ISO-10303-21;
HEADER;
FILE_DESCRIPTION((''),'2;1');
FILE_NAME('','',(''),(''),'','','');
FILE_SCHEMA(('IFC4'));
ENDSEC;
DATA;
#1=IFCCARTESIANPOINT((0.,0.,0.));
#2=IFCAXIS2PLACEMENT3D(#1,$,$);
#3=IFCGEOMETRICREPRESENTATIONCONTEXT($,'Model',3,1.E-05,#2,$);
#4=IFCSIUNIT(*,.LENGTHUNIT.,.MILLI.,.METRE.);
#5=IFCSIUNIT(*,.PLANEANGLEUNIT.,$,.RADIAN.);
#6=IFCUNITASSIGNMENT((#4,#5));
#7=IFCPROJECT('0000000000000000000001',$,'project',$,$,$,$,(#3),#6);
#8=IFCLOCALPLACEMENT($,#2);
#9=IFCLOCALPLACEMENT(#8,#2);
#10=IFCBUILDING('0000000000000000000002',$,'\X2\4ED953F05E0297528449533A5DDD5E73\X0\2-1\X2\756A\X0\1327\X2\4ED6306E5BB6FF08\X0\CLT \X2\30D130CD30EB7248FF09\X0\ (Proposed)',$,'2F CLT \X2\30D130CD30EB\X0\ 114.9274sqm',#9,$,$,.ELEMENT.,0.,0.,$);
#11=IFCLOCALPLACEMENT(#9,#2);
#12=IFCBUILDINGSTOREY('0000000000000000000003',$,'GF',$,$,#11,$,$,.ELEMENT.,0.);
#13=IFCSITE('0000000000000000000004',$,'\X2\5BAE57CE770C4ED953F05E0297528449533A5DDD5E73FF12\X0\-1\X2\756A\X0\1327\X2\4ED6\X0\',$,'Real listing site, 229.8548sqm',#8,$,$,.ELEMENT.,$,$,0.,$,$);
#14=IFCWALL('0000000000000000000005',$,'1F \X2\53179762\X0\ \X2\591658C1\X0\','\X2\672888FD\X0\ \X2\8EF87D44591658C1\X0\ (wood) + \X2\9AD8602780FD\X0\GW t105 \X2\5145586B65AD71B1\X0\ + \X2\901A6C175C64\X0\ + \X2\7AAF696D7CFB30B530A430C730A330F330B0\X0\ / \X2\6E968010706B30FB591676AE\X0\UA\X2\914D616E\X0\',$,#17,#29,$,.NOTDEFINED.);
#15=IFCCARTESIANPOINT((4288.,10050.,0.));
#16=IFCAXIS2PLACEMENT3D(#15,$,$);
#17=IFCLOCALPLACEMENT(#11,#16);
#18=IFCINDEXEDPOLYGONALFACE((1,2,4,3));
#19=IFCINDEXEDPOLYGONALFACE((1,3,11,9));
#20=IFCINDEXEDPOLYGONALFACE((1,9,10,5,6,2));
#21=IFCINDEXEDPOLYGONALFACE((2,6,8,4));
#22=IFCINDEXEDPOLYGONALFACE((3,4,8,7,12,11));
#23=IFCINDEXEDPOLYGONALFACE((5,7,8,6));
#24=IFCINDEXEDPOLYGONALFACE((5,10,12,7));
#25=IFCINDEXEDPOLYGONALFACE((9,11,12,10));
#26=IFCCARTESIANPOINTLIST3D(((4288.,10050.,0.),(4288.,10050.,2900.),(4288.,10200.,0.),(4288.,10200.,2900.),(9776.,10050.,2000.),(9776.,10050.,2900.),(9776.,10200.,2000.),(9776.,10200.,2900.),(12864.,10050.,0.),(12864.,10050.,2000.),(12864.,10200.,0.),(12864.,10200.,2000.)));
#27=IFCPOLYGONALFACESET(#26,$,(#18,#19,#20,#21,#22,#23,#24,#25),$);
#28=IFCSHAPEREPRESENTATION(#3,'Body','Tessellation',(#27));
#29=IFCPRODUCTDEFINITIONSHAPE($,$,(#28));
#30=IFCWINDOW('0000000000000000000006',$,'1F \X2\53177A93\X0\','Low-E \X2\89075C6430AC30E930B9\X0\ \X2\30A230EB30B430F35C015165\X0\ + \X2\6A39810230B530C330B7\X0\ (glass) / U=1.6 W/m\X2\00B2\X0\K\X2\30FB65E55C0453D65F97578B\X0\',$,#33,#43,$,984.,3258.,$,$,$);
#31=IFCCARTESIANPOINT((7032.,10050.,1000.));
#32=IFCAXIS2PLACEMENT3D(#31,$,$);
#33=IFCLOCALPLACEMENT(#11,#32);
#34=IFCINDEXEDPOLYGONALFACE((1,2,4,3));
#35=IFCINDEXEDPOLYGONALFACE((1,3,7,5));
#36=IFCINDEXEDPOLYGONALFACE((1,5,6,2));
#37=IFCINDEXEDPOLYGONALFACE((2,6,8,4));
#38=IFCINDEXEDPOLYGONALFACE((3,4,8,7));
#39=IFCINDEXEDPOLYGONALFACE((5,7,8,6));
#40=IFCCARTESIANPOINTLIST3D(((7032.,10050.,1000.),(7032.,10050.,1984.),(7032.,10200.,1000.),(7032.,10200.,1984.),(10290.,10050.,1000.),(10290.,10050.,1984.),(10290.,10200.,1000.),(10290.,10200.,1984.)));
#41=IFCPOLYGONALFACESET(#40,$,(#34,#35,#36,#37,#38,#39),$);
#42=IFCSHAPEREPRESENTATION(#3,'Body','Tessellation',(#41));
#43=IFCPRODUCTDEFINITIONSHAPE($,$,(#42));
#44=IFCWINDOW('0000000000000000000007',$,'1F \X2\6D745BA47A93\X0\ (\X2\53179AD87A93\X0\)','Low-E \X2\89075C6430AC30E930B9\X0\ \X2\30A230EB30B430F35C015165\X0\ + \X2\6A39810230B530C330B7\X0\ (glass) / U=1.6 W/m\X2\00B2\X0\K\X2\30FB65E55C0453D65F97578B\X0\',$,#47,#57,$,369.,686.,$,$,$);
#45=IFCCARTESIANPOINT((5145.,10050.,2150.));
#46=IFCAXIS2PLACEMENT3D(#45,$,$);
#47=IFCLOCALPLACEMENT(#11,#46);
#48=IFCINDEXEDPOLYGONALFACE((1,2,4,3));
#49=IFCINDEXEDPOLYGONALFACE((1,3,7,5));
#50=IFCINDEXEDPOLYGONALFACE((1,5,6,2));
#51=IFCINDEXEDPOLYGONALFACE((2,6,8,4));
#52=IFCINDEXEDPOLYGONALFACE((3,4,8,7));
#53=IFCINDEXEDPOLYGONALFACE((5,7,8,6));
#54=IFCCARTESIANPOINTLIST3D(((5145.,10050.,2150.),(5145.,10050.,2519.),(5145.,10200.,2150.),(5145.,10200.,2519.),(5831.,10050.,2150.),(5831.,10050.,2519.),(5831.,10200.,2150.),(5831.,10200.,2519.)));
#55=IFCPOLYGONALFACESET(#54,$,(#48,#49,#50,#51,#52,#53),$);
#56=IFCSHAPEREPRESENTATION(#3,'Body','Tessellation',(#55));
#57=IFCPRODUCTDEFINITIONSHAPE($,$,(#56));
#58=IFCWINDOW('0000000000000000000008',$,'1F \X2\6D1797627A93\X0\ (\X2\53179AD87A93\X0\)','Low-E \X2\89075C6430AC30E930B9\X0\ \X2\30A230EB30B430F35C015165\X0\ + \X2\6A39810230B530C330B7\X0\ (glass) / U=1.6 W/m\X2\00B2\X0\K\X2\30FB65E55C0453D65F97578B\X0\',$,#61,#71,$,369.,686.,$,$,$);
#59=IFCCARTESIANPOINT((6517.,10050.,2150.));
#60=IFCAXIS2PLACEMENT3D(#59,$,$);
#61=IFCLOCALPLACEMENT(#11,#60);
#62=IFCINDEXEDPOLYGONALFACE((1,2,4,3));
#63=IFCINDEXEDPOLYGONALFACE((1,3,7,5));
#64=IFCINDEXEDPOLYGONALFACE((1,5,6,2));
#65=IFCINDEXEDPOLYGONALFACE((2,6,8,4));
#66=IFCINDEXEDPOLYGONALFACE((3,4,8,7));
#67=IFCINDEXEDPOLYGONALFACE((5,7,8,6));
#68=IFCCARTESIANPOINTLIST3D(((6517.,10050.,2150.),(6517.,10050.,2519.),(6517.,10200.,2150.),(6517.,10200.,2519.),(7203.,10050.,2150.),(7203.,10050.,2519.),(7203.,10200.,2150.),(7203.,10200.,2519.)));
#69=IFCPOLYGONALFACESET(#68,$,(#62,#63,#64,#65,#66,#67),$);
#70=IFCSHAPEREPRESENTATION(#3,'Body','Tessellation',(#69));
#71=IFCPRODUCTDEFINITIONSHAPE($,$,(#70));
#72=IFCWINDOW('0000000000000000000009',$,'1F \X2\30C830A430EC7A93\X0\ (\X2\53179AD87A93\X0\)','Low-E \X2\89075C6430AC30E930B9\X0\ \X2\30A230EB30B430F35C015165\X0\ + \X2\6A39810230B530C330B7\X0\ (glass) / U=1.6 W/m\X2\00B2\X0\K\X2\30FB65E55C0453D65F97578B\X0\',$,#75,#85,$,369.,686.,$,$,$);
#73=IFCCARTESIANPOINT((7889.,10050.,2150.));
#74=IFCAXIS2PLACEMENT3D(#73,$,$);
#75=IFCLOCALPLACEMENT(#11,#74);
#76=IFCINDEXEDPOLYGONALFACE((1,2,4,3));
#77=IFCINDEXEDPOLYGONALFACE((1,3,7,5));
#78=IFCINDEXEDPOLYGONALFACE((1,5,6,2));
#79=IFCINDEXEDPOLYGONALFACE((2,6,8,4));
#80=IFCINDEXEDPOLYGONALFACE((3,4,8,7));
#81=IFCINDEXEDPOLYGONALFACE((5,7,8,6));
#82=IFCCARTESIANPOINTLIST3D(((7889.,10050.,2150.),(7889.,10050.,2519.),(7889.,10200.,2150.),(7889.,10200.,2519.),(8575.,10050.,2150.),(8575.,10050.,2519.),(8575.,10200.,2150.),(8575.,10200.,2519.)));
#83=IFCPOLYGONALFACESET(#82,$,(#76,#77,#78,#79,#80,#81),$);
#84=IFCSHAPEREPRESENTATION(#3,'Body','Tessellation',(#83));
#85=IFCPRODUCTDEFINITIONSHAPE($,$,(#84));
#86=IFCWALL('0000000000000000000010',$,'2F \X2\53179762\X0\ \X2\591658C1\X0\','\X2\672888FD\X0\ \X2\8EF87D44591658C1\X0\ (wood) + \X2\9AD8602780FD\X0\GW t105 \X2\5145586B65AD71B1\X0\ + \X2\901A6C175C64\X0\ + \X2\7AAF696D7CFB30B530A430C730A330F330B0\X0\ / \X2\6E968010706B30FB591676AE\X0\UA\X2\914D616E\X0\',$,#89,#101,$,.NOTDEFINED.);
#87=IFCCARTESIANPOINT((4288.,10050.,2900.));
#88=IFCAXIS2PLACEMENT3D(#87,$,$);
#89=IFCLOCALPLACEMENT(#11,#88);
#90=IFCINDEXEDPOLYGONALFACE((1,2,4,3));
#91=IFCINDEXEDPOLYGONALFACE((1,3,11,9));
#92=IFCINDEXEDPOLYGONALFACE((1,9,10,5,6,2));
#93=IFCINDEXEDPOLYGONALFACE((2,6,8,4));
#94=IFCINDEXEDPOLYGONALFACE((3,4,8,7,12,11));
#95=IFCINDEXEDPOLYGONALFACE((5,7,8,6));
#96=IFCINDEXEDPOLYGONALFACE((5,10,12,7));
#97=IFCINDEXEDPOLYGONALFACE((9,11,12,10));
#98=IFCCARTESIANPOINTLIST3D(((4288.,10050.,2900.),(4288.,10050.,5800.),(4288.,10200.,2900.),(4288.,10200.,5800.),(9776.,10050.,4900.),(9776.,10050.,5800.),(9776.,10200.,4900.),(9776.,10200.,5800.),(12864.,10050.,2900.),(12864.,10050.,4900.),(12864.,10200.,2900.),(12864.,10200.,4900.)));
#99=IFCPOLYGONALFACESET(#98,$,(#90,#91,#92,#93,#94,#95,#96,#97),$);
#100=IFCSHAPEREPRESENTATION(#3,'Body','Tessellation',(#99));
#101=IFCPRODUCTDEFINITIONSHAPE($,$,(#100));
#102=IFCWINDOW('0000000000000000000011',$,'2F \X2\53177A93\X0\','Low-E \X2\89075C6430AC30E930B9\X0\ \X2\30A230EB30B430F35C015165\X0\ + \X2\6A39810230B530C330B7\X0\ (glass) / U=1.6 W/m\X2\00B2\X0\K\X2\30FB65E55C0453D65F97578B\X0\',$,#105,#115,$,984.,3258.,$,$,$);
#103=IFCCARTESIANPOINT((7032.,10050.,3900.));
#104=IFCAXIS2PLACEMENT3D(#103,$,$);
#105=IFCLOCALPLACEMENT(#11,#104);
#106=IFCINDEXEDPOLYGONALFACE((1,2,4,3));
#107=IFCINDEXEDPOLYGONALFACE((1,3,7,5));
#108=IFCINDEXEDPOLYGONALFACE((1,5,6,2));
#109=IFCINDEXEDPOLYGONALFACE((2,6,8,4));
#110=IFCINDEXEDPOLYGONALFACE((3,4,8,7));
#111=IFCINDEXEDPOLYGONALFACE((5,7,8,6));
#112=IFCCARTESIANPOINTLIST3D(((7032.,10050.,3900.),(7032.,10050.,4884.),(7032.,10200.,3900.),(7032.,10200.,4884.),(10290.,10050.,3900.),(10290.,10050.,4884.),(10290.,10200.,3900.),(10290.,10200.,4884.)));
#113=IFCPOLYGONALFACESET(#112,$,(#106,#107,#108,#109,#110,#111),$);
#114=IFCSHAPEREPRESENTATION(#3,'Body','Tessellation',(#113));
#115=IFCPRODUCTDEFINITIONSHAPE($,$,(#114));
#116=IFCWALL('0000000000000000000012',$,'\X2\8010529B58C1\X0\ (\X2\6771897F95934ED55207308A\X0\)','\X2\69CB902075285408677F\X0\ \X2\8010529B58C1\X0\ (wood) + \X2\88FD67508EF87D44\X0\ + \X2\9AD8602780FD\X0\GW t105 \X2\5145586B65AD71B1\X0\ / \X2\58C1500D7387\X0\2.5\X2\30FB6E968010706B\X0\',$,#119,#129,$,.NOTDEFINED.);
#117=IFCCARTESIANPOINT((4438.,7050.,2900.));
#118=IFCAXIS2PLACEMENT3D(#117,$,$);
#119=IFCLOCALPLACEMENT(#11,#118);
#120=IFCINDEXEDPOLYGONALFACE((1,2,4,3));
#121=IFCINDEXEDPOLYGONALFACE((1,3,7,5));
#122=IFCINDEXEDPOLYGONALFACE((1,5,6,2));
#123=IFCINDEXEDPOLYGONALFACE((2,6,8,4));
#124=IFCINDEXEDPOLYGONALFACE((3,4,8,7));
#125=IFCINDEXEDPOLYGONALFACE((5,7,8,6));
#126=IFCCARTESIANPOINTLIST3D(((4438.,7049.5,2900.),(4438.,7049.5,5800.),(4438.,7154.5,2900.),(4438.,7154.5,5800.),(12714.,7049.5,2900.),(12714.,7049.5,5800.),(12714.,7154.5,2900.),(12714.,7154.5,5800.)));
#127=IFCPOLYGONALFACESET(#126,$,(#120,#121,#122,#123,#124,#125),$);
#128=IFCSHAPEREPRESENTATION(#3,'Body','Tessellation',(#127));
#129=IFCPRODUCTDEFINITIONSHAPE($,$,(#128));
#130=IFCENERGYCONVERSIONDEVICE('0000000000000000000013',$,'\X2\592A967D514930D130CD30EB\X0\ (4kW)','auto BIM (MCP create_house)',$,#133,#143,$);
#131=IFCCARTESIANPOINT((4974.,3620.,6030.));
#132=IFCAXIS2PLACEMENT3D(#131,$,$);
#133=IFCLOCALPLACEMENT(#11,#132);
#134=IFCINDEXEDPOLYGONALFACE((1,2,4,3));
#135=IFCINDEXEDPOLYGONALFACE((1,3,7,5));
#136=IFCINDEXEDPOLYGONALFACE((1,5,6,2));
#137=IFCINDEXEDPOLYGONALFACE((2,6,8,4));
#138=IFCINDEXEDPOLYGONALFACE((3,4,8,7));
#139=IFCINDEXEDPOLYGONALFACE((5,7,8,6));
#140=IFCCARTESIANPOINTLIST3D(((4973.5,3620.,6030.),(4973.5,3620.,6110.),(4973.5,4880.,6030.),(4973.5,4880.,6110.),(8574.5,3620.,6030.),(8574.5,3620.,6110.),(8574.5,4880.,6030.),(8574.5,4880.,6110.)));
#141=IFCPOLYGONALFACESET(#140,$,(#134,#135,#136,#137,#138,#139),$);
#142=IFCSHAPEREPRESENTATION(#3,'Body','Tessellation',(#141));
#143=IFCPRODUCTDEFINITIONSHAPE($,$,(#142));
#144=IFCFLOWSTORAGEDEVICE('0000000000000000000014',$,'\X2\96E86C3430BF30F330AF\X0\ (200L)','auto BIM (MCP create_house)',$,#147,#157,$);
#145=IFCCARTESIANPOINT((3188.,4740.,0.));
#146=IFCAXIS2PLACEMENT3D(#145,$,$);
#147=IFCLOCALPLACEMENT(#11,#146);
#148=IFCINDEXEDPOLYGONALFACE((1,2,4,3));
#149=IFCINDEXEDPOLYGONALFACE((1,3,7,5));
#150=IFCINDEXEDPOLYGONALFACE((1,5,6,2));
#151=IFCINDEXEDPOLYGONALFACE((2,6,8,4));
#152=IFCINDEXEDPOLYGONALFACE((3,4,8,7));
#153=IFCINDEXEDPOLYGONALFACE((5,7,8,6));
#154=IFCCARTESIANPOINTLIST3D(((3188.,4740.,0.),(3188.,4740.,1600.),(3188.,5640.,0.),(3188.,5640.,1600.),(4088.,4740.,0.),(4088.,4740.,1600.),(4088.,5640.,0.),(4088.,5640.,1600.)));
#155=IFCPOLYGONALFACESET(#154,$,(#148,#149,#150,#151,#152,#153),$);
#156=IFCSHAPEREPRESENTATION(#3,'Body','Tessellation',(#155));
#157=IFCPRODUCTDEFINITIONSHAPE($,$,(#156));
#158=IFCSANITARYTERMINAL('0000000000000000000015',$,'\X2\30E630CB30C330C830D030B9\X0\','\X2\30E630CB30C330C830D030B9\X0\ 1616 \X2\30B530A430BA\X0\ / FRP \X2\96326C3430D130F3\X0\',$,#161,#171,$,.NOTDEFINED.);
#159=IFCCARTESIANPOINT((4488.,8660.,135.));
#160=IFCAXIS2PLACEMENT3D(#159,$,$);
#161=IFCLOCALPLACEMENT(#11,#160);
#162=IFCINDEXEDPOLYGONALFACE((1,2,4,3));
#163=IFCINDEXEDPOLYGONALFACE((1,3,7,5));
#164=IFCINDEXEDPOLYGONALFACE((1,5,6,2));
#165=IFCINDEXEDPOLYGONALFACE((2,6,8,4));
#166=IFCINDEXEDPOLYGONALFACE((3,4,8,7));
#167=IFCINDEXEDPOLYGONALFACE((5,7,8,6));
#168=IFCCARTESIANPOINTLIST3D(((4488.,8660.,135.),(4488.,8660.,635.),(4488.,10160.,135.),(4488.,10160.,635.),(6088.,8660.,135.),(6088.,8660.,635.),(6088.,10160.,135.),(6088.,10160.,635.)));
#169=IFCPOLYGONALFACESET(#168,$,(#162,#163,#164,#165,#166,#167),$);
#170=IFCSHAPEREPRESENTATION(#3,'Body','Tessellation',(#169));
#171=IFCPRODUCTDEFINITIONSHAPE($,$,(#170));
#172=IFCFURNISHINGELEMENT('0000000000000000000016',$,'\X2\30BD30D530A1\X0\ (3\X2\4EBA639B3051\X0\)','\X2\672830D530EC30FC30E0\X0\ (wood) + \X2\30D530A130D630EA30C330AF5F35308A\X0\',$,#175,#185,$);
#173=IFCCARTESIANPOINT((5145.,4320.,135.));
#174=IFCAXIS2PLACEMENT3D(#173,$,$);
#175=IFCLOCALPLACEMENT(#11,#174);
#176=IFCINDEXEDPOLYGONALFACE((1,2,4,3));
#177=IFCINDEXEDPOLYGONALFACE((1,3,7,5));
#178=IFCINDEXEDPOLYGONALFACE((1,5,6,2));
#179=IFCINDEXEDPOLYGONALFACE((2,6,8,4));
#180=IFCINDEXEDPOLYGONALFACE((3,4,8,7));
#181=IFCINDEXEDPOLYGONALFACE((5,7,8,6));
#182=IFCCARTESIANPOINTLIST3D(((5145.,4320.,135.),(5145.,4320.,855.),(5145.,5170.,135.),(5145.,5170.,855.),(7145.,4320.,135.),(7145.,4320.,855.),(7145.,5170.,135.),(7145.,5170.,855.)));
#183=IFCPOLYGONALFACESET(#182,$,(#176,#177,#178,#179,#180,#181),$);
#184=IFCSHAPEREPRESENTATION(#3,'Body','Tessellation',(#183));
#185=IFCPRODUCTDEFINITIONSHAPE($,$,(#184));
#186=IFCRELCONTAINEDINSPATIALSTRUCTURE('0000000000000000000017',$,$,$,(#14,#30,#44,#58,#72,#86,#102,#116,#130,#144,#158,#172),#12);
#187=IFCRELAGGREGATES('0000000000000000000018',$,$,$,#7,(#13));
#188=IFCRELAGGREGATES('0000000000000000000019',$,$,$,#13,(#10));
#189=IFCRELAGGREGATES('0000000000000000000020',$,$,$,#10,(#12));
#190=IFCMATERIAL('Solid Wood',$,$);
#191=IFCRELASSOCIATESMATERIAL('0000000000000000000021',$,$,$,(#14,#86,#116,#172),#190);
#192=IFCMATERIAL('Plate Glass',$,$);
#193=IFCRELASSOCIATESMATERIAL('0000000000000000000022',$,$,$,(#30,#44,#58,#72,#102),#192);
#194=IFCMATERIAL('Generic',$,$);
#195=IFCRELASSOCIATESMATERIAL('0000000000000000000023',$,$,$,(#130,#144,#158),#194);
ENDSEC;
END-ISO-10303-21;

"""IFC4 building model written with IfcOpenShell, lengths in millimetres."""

from ifc_helpers import new_model, si_unit, frame, frame_2d, origin, place, context, project, spatial, rectangle, extrude, material, element, fill, save


model = new_model("IFC4")

# Units and contexts
model_context = context("Model", 3, precision=1e-05, world=origin())
ifc_project = project(units=[si_unit("LENGTHUNIT", "METRE", prefix="MILLI"), si_unit("PLANEANGLEUNIT", "RADIAN")], contexts=[model_context])

# Site, building, storey
site_placement = place(None, origin())
site = spatial("IfcSite", under=ifc_project, at=site_placement, Name="宮城県仙台市青葉区川平２-1番1327他", ObjectType="Real listing site, 229.8548sqm", CompositionType="ELEMENT", RefElevation=0.0)
building_placement = place(site_placement, origin())
building = spatial("IfcBuilding", under=site, at=building_placement, Name="仙台市青葉区川平2-1番1327他の家（CLT パネル版） (Proposed)", ObjectType="2F CLT パネル 114.9274sqm", CompositionType="ELEMENT", ElevationOfRefHeight=0.0, ElevationOfTerrain=0.0)
storey_placement = place(building_placement, origin())
storey = spatial("IfcBuildingStorey", under=building, at=storey_placement, Name="GF", CompositionType="ELEMENT", Elevation=0.0)

# Wall, openings, windows
ifc_material_1 = material(Name="Solid Wood")
wall_1_placement = place(storey_placement, frame((4288.0, 10050.0, 0.0)))
wall_1 = element("IfcWall", 1, at=wall_1_placement, inside=storey, material=ifc_material_1, Name="1F 北面 外壁", Description="木製 軸組外壁 (wood) + 高性能GW t105 充填断熱 + 通気層 + 窯業系サイディング / 準耐火・外皮UA配慮", PredefinedType="NOTDEFINED", context=model_context, shape_type="SweptSolid", body=[
    extrude(rectangle(XDim=8576.0, YDim=150.0, at=frame_2d((4288.0, 75.0))), frame((4288.0, 10050.0, 0.0)), (0.0, 0.0, 1.0), 2900.0),
])
opening_1_placement = place(storey_placement, frame((7032.0, 10050.0, 1000.0)))
opening_1 = element("IfcOpeningElement", 2, at=opening_1_placement, cuts=wall_1, PredefinedType="NOTDEFINED", context=model_context, shape_type="SweptSolid", body=[
    extrude(rectangle(XDim=3258.0, YDim=150.0, at=frame_2d((1629.0, 75.0))), frame((7032.0, 10050.0, 1000.0)), (0.0, 0.0, 1.0), 984.0),
])
opening_2_placement = place(storey_placement, frame((5145.0, 10050.0, 2150.0)))
opening_2 = element("IfcOpeningElement", 3, at=opening_2_placement, cuts=wall_1, PredefinedType="NOTDEFINED", context=model_context, shape_type="SweptSolid", body=[
    extrude(rectangle(XDim=686.0, YDim=150.0, at=frame_2d((343.0, 75.0))), frame((5145.0, 10050.0, 2150.0)), (0.0, 0.0, 1.0), 369.0),
])
opening_3_placement = place(storey_placement, frame((6517.0, 10050.0, 2150.0)))
opening_3 = element("IfcOpeningElement", 4, at=opening_3_placement, cuts=wall_1, PredefinedType="NOTDEFINED", context=model_context, shape_type="SweptSolid", body=[
    extrude(rectangle(XDim=686.0, YDim=150.0, at=frame_2d((343.0, 75.0))), frame((6517.0, 10050.0, 2150.0)), (0.0, 0.0, 1.0), 369.0),
])
opening_4_placement = place(storey_placement, frame((7889.0, 10050.0, 2150.0)))
opening_4 = element("IfcOpeningElement", 5, at=opening_4_placement, cuts=wall_1, PredefinedType="NOTDEFINED", context=model_context, shape_type="SweptSolid", body=[
    extrude(rectangle(XDim=686.0, YDim=150.0, at=frame_2d((343.0, 75.0))), frame((7889.0, 10050.0, 2150.0)), (0.0, 0.0, 1.0), 369.0),
])
ifc_material_2 = material(Name="Plate Glass")
window_1_placement = place(storey_placement, frame((7032.0, 10050.0, 1000.0)))
window_1 = element("IfcWindow", 6, at=window_1_placement, inside=storey, material=ifc_material_2, Name="1F 北窓", Description="Low-E 複層ガラス アルゴン封入 + 樹脂サッシ (glass) / U=1.6 W/m²K・日射取得型", OverallHeight=984.0, OverallWidth=3258.0, context=model_context, shape_type="SweptSolid", body=[
    extrude(rectangle(XDim=3258.0, YDim=150.0, at=frame_2d((1629.0, 75.0))), frame((7032.0, 10050.0, 1000.0)), (0.0, 0.0, 1.0), 984.0),
])
fill(opening_1, window_1)
window_2_placement = place(storey_placement, frame((5145.0, 10050.0, 2150.0)))
window_2 = element("IfcWindow", 7, at=window_2_placement, inside=storey, material=ifc_material_2, Name="1F 浴室窓 (北高窓)", Description="Low-E 複層ガラス アルゴン封入 + 樹脂サッシ (glass) / U=1.6 W/m²K・日射取得型", OverallHeight=369.0, OverallWidth=686.0, context=model_context, shape_type="SweptSolid", body=[
    extrude(rectangle(XDim=686.0, YDim=150.0, at=frame_2d((343.0, 75.0))), frame((5145.0, 10050.0, 2150.0)), (0.0, 0.0, 1.0), 369.0),
])
fill(opening_2, window_2)
window_3_placement = place(storey_placement, frame((6517.0, 10050.0, 2150.0)))
window_3 = element("IfcWindow", 8, at=window_3_placement, inside=storey, material=ifc_material_2, Name="1F 洗面窓 (北高窓)", Description="Low-E 複層ガラス アルゴン封入 + 樹脂サッシ (glass) / U=1.6 W/m²K・日射取得型", OverallHeight=369.0, OverallWidth=686.0, context=model_context, shape_type="SweptSolid", body=[
    extrude(rectangle(XDim=686.0, YDim=150.0, at=frame_2d((343.0, 75.0))), frame((6517.0, 10050.0, 2150.0)), (0.0, 0.0, 1.0), 369.0),
])
fill(opening_3, window_3)
window_4_placement = place(storey_placement, frame((7889.0, 10050.0, 2150.0)))
window_4 = element("IfcWindow", 9, at=window_4_placement, inside=storey, material=ifc_material_2, Name="1F トイレ窓 (北高窓)", Description="Low-E 複層ガラス アルゴン封入 + 樹脂サッシ (glass) / U=1.6 W/m²K・日射取得型", OverallHeight=369.0, OverallWidth=686.0, context=model_context, shape_type="SweptSolid", body=[
    extrude(rectangle(XDim=686.0, YDim=150.0, at=frame_2d((343.0, 75.0))), frame((7889.0, 10050.0, 2150.0)), (0.0, 0.0, 1.0), 369.0),
])
fill(opening_4, window_4)

# Wall, opening, window
wall_2_placement = place(storey_placement, frame((4288.0, 10050.0, 2900.0)))
wall_2 = element("IfcWall", 10, at=wall_2_placement, inside=storey, material=ifc_material_1, Name="2F 北面 外壁", Description="木製 軸組外壁 (wood) + 高性能GW t105 充填断熱 + 通気層 + 窯業系サイディング / 準耐火・外皮UA配慮", PredefinedType="NOTDEFINED", context=model_context, shape_type="SweptSolid", body=[
    extrude(rectangle(XDim=8576.0, YDim=150.0, at=frame_2d((4288.0, 75.0))), frame((4288.0, 10050.0, 2900.0)), (0.0, 0.0, 1.0), 2900.0),
])
opening_5_placement = place(storey_placement, frame((7032.0, 10050.0, 3900.0)))
opening_5 = element("IfcOpeningElement", 11, at=opening_5_placement, cuts=wall_2, PredefinedType="NOTDEFINED", context=model_context, shape_type="SweptSolid", body=[
    extrude(rectangle(XDim=3258.0, YDim=150.0, at=frame_2d((1629.0, 75.0))), frame((7032.0, 10050.0, 3900.0)), (0.0, 0.0, 1.0), 984.0),
])
window_5_placement = place(storey_placement, frame((7032.0, 10050.0, 3900.0)))
window_5 = element("IfcWindow", 12, at=window_5_placement, inside=storey, material=ifc_material_2, Name="2F 北窓", Description="Low-E 複層ガラス アルゴン封入 + 樹脂サッシ (glass) / U=1.6 W/m²K・日射取得型", OverallHeight=984.0, OverallWidth=3258.0, context=model_context, shape_type="SweptSolid", body=[
    extrude(rectangle(XDim=3258.0, YDim=150.0, at=frame_2d((1629.0, 75.0))), frame((7032.0, 10050.0, 3900.0)), (0.0, 0.0, 1.0), 984.0),
])
fill(opening_5, window_5)

# Wall
wall_3_placement = place(storey_placement, frame((4438.0, 7050.0, 2900.0)))
element("IfcWall", 13, at=wall_3_placement, inside=storey, material=ifc_material_1, Name="耐力壁 (東西間仕切り)", Description="構造用合板 耐力壁 (wood) + 製材軸組 + 高性能GW t105 充填断熱 / 壁倍率2.5・準耐火", PredefinedType="NOTDEFINED", context=model_context, shape_type="SweptSolid", body=[
    extrude(rectangle(XDim=8276.0, YDim=105.0, at=frame_2d((4138.0, 52.0))), frame((4438.0, 7050.0, 2900.0)), (0.0, 0.0, 1.0), 2900.0),
])

# Energy conversion device
ifc_material_3 = material(Name="Generic")
energy_conversion_device_placement = place(storey_placement, frame((4974.0, 3620.0, 6030.0)))
element("IfcEnergyConversionDevice", 14, at=energy_conversion_device_placement, inside=storey, material=ifc_material_3, Name="太陽光パネル (4kW)", Description="auto BIM (MCP create_house)", context=model_context, shape_type="SweptSolid", body=[
    extrude(rectangle(XDim=3601.0, YDim=1260.0, at=frame_2d((1800.0, 630.0))), frame((4974.0, 3620.0, 6030.0)), (0.0, 0.0, 1.0), 80.0),
])

# Flow storage device
flow_storage_device_placement = place(storey_placement, frame((3188.0, 4740.0, 0.0)))
element("IfcFlowStorageDevice", 15, at=flow_storage_device_placement, inside=storey, material=ifc_material_3, Name="雨水タンク (200L)", Description="auto BIM (MCP create_house)", context=model_context, shape_type="SweptSolid", body=[
    extrude(rectangle(XDim=900.0, YDim=900.0, at=frame_2d((450.0, 450.0))), frame((3188.0, 4740.0, 0.0)), (0.0, 0.0, 1.0), 1600.0),
])

# Sanitary terminal
sanitary_terminal_placement = place(storey_placement, frame((4488.0, 8660.0, 135.0)))
element("IfcSanitaryTerminal", 16, at=sanitary_terminal_placement, inside=storey, material=ifc_material_3, Name="ユニットバス", Description="ユニットバス 1616 サイズ / FRP 防水パン", PredefinedType="NOTDEFINED", context=model_context, shape_type="SweptSolid", body=[
    extrude(rectangle(XDim=1600.0, YDim=1500.0, at=frame_2d((800.0, 750.0))), frame((4488.0, 8660.0, 135.0)), (0.0, 0.0, 1.0), 500.0),
])

# Furnishing element
furnishing_1_placement = place(storey_placement, frame((5145.0, 4320.0, 135.0)))
element("IfcFurnishingElement", 17, at=furnishing_1_placement, inside=storey, material=ifc_material_1, Name="ソファ (3人掛け)", Description="木フレーム (wood) + ファブリック張り", context=model_context, shape_type="SweptSolid", body=[
    extrude(rectangle(XDim=2000.0, YDim=850.0, at=frame_2d((1000.0, 425.0))), frame((5145.0, 4320.0, 135.0)), (0.0, 0.0, 1.0), 720.0),
])

save(model, "model.ifc")
